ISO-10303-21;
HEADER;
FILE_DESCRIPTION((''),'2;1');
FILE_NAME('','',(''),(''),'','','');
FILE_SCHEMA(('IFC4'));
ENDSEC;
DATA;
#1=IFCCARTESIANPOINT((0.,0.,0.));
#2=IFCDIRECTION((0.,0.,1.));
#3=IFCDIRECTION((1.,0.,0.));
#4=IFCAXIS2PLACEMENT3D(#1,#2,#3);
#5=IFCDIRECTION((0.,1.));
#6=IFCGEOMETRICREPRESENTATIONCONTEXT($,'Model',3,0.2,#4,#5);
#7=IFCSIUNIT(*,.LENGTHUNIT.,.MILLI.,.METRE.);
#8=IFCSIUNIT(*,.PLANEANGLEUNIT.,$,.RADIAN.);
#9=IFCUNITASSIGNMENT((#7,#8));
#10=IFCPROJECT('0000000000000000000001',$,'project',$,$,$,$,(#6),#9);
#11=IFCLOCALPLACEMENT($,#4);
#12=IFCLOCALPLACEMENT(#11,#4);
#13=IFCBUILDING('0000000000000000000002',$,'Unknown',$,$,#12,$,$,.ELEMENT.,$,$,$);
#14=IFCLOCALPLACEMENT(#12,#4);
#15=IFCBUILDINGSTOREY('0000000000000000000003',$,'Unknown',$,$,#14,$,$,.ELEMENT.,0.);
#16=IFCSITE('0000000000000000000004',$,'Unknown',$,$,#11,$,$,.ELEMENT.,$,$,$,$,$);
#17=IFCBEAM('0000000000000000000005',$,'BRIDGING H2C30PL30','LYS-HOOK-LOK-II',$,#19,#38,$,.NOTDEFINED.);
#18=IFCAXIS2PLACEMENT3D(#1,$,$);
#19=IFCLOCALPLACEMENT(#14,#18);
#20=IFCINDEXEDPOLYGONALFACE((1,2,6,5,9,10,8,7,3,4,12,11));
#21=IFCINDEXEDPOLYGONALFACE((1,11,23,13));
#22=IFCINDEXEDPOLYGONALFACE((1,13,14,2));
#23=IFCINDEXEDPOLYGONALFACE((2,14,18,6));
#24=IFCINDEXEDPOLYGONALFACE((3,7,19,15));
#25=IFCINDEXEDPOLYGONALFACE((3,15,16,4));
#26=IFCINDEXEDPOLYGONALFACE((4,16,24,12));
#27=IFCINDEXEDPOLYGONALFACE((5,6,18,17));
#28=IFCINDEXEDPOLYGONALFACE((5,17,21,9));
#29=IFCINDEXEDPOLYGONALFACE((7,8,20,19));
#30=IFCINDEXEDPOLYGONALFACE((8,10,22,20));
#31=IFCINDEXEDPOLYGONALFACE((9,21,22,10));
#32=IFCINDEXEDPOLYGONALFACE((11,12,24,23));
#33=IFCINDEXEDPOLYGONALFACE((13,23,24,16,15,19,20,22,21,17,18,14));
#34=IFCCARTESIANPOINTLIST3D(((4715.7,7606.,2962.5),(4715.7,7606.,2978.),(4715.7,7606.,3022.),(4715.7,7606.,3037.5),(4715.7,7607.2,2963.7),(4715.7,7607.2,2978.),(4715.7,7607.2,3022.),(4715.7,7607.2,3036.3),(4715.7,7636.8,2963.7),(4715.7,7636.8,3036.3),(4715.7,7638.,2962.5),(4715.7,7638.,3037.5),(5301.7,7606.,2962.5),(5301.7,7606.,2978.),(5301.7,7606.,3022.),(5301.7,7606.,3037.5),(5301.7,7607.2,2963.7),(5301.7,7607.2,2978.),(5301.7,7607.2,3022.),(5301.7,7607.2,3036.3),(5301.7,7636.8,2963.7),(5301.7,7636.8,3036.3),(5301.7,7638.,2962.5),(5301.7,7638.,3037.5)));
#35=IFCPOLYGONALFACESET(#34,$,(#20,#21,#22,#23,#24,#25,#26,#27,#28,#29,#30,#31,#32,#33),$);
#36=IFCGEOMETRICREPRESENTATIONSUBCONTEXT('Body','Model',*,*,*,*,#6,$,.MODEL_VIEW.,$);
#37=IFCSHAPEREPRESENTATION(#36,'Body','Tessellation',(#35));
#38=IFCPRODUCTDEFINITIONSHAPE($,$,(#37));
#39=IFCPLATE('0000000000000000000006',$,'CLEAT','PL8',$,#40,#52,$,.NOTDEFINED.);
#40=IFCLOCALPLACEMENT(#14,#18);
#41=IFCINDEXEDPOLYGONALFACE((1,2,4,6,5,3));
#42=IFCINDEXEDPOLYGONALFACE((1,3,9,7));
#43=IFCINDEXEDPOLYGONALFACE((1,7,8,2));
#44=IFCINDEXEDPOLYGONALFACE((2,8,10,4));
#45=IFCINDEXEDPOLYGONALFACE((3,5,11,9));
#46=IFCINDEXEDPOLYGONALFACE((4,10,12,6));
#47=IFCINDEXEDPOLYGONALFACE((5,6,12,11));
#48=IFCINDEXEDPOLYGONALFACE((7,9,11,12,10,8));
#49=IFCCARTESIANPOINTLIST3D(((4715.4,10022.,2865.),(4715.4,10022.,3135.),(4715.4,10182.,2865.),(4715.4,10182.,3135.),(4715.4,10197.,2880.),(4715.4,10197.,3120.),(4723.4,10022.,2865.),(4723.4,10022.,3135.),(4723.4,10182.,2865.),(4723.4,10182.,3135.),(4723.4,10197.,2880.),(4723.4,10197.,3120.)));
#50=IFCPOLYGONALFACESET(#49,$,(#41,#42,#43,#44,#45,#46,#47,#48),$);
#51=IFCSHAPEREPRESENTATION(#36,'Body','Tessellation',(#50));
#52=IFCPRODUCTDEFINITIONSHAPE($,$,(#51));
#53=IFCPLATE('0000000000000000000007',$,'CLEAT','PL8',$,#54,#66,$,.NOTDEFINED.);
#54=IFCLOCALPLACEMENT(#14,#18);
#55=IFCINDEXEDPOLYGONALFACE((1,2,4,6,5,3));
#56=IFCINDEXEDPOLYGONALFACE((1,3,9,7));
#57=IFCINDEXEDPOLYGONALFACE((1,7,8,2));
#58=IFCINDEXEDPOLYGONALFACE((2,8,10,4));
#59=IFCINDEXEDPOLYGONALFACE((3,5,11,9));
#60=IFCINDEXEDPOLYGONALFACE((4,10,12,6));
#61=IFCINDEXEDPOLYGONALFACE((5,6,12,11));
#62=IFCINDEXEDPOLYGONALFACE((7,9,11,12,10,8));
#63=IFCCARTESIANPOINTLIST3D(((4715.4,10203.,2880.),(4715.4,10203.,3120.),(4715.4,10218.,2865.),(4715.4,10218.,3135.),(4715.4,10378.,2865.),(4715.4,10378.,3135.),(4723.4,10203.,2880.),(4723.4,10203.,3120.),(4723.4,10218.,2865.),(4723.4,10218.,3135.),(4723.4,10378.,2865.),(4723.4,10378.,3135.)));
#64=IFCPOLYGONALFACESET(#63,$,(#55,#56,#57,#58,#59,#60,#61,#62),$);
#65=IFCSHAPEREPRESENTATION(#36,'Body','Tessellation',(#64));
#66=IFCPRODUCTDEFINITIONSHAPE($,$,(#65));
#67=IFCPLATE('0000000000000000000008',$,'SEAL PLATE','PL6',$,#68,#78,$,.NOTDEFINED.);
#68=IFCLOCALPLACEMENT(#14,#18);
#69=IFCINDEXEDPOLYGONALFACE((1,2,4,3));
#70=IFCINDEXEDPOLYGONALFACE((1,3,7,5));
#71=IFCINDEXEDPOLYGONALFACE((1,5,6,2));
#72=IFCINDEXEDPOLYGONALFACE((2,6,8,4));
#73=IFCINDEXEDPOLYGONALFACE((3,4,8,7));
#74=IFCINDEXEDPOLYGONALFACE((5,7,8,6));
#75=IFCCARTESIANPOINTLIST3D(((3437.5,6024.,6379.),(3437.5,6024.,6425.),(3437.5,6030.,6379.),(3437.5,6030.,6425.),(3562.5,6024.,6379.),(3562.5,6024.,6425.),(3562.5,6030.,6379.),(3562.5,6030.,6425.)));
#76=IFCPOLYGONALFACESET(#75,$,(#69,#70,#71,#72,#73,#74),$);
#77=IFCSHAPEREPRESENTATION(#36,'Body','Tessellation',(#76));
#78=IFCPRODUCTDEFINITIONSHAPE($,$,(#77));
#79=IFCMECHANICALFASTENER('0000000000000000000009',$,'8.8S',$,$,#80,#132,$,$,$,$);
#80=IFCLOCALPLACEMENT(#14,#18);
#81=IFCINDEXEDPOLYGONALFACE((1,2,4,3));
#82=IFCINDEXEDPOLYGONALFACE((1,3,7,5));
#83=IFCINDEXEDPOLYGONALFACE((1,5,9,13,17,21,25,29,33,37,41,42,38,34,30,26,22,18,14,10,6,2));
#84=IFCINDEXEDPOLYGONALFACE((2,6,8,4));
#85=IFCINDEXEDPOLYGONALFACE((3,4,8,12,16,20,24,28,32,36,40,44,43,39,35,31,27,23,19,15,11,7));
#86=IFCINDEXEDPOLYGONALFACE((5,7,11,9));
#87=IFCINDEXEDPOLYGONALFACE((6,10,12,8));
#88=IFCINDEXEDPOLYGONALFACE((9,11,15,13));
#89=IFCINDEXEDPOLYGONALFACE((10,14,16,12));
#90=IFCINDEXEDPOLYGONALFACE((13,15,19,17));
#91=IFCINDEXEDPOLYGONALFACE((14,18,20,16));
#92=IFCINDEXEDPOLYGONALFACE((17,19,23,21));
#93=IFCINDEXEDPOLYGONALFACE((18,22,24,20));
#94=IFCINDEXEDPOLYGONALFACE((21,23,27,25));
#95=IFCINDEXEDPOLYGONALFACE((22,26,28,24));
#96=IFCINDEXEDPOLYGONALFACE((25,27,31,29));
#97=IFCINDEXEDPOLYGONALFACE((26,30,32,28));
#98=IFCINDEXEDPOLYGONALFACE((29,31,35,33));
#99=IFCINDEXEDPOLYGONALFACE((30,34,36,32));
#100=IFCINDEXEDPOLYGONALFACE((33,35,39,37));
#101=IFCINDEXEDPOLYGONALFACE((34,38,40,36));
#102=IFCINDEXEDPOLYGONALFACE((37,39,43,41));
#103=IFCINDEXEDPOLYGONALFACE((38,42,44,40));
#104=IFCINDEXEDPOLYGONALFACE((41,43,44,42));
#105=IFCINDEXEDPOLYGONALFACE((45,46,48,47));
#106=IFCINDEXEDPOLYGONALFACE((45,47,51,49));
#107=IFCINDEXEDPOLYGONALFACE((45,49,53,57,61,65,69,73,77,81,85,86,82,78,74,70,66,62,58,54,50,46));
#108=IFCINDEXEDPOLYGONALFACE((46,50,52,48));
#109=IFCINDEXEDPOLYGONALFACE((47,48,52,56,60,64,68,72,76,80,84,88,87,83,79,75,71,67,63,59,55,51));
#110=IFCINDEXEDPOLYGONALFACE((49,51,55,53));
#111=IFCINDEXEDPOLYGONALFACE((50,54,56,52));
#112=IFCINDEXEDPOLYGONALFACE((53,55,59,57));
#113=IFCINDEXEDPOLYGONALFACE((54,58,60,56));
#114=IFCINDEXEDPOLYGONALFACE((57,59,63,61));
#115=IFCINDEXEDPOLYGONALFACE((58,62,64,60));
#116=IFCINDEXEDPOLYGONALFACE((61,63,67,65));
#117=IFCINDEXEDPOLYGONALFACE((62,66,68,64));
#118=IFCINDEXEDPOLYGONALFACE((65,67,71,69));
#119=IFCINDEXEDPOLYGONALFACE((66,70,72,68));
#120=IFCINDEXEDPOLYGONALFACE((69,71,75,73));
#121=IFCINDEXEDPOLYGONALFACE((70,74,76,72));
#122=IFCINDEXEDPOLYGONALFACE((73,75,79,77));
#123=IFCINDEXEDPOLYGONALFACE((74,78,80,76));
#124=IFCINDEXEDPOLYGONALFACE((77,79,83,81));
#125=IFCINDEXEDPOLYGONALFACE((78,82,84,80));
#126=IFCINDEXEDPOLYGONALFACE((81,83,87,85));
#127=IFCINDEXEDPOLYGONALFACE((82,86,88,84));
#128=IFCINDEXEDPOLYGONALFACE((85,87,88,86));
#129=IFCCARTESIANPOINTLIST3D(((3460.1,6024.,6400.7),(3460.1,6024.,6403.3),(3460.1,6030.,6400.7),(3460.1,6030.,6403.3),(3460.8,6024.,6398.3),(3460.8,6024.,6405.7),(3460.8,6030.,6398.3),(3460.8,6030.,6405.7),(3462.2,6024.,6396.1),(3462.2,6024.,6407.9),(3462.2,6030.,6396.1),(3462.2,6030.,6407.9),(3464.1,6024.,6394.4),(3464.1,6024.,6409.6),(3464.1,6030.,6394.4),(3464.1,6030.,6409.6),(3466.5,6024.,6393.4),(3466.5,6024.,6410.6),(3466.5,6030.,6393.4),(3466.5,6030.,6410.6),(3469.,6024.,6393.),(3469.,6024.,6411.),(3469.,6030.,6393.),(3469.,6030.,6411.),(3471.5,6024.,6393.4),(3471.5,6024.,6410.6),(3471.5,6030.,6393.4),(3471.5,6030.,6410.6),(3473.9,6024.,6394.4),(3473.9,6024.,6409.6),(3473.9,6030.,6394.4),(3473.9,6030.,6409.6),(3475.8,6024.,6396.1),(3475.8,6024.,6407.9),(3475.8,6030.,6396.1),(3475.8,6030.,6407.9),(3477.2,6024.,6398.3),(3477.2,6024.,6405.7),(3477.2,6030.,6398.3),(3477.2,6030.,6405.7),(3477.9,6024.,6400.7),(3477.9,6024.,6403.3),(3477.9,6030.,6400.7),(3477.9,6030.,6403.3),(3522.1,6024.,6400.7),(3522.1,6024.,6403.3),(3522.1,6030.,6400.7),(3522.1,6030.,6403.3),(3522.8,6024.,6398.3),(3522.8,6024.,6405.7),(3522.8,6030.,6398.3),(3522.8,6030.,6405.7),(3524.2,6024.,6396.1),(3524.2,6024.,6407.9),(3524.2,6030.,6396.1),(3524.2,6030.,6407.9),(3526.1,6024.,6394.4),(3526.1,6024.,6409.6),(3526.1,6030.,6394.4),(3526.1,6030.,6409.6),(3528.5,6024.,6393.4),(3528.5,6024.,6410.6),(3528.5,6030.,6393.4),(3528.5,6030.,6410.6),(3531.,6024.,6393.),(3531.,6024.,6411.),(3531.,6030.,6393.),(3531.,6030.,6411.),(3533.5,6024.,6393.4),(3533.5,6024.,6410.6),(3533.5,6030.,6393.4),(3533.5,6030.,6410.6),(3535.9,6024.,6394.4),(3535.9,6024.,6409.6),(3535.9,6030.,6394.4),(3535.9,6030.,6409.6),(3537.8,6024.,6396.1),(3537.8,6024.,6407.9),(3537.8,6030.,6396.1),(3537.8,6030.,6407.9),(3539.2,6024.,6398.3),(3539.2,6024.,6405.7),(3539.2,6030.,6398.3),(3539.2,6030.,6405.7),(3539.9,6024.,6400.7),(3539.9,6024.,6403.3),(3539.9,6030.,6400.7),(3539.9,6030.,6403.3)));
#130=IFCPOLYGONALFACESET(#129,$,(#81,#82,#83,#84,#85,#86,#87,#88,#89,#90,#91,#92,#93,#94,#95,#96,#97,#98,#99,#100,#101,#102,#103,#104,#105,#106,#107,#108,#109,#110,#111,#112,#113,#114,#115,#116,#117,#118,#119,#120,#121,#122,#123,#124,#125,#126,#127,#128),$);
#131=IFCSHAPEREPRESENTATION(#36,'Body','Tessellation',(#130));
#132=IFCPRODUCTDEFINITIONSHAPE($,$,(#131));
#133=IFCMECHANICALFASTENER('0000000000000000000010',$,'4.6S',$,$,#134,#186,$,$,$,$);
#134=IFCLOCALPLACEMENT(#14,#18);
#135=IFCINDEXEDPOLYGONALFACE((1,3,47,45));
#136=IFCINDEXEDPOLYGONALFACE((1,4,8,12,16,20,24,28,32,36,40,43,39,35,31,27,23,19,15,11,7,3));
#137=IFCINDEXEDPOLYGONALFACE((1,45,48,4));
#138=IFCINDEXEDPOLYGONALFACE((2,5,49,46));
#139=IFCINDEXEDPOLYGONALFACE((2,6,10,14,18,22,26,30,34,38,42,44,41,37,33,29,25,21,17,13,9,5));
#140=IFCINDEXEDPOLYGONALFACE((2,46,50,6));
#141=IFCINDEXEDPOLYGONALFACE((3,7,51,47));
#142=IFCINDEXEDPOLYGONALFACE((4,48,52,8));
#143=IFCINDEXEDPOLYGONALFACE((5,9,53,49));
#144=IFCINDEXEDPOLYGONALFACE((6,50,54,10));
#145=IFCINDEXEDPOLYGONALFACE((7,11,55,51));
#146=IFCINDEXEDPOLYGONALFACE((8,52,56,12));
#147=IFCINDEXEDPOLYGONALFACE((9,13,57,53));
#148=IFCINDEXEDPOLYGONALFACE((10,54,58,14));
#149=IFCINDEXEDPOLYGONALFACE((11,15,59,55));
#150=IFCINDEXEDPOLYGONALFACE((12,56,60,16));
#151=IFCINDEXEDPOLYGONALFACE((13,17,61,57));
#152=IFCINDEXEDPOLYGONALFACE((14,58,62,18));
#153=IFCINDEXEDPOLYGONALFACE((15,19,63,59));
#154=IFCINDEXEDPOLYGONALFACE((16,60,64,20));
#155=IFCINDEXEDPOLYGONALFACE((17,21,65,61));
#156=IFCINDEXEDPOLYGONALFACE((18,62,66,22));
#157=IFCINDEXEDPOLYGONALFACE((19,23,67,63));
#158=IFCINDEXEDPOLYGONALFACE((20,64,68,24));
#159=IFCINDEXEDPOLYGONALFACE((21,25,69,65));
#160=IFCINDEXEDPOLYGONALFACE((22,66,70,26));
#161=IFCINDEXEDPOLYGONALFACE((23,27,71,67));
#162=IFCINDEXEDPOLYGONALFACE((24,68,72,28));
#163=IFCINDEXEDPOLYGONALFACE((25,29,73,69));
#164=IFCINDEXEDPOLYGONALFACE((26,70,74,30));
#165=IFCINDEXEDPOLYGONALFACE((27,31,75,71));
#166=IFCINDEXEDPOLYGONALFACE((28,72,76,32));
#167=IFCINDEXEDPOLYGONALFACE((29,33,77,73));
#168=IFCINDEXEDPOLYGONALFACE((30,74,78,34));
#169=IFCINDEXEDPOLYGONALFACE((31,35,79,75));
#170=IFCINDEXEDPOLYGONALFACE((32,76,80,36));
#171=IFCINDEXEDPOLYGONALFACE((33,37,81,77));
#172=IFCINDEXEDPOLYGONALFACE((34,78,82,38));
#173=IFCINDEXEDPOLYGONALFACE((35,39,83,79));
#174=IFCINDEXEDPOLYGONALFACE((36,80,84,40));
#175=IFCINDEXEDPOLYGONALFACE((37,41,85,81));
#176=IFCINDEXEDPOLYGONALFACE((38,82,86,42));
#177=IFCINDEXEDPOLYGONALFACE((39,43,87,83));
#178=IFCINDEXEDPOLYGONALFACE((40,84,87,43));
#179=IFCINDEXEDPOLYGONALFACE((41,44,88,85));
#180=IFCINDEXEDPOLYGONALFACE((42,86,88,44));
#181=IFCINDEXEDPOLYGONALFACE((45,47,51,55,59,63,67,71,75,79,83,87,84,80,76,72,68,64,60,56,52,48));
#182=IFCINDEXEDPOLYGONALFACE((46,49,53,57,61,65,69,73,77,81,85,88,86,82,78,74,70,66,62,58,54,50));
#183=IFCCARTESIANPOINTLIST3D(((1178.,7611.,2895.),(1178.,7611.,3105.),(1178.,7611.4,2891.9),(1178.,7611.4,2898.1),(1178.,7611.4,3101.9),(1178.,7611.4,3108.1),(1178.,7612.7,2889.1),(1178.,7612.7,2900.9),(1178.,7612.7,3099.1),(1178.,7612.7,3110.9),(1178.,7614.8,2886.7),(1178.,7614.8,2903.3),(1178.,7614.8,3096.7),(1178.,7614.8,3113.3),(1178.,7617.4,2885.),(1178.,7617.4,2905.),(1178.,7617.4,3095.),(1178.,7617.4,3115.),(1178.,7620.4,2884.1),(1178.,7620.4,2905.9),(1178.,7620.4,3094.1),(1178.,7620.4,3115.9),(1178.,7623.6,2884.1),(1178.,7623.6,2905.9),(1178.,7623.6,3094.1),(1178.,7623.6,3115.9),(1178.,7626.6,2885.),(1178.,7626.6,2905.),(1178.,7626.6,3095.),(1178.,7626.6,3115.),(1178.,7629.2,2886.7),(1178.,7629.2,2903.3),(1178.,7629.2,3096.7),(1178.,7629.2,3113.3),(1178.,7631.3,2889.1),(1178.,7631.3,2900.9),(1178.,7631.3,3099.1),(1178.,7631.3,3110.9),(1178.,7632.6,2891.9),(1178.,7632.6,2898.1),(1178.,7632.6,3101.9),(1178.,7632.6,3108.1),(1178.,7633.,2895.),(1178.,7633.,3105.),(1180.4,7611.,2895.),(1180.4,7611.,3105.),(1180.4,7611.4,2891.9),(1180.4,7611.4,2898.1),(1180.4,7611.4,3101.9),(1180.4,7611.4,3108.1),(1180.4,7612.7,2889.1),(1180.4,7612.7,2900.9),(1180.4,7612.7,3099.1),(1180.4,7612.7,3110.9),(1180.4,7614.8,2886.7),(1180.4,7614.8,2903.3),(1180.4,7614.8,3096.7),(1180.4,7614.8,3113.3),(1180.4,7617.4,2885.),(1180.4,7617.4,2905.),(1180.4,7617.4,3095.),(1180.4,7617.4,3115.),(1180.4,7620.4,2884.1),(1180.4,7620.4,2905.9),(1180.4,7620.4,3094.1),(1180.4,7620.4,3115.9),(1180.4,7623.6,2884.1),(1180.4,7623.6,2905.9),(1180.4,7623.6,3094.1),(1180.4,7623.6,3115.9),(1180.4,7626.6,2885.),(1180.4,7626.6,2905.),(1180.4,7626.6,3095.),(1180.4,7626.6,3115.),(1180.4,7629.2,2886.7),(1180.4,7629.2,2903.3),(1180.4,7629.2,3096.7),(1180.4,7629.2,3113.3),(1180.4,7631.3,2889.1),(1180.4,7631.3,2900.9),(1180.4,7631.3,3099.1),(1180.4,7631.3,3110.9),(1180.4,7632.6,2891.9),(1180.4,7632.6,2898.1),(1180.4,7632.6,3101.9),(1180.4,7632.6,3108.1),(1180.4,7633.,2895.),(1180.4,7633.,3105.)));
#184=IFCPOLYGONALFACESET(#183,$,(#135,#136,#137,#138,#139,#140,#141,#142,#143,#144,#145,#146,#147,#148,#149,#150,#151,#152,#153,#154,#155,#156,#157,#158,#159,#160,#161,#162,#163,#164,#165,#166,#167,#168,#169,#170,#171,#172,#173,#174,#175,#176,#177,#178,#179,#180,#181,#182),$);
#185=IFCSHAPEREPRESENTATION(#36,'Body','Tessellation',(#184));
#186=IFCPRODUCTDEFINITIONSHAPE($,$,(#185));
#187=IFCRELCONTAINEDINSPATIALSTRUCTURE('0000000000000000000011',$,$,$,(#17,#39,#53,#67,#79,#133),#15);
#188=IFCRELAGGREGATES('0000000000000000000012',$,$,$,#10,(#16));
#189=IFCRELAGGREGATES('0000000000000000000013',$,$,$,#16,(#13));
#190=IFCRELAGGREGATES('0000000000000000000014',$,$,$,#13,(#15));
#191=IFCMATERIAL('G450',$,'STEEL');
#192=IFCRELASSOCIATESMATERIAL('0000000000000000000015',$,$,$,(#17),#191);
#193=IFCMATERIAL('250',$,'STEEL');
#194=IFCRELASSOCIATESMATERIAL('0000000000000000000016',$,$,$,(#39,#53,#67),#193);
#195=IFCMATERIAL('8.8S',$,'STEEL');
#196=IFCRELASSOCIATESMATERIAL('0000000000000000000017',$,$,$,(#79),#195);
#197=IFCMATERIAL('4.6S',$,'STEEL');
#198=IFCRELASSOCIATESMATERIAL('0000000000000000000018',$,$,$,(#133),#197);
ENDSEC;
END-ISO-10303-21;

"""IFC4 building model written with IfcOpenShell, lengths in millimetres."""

from ifc_helpers import new_model, si_unit, direction, frame, origin_with_axes, place, context, subcontext, project, spatial, line, arc, indexed_curve, outline, extrude, source, transform, mapped, material, element, save


model = new_model("IFC4")

# Units and contexts
model_context = context("Model", 3, precision=0.2, world=origin_with_axes(), true_north=direction((0.0, 1.0)))
body_context = subcontext(model_context, "Body", "Model", "MODEL_VIEW")
ifc_project = project(units=[si_unit("LENGTHUNIT", "METRE", prefix="MILLI"), si_unit("PLANEANGLEUNIT", "RADIAN")], contexts=[model_context])

# Site, building, storey
site_placement = place(None, origin_with_axes())
site = spatial("IfcSite", under=ifc_project, at=site_placement, Name="Unknown", CompositionType="ELEMENT")
building_placement = place(site_placement, origin_with_axes())
building = spatial("IfcBuilding", under=site, at=building_placement, Name="Unknown", CompositionType="ELEMENT")
storey_placement = place(building_placement, origin_with_axes())
storey = spatial("IfcBuildingStorey", under=building, at=storey_placement, Name="Unknown", CompositionType="ELEMENT", Elevation=0.0)

# Beam
ifc_material_1 = material(Name="G450", Category="STEEL")
for number, where, z_axis, x_axis, name in (
    (1, (4715.7, 7622.0, 3000.0), (0.0, -1.0, 0.0), (1.0, 0.0, 0.0), "BRIDGING H2C30PL30"),
):
    element("IfcBeam", number, at=place(storey_placement, frame(where, z_axis=z_axis, x_axis=x_axis)), inside=storey, material=ifc_material_1, Name=name, Description="LYS-HOOK-LOK-II", PredefinedType="NOTDEFINED", context=body_context, shape_type="SolidModel", body=[
        extrude(outline(indexed_curve([(16.0, -37.5), (16.0, -22.0), (14.8, -22.0), (14.8, -36.3), (-14.8, -36.3), (-14.8, 36.3), (14.8, 36.3), (14.8, 22.0), (16.0, 22.0), (16.0, 37.5), (-16.0, 37.5), (-16.0, -37.5)], segments=[line(1, 2, 3, 4, 5, 6, 7, 8, 9, 10, 11, 12, 1)])), frame((0.0, 0.0, 0.0), z_axis=(-1.0, 0.0, 0.0), x_axis=(0.0, 0.0, 1.0)), (0.0, 0.0, -1.0), 586.0),
    ])

# Plates
ifc_material_2 = material(Name="250", Category="STEEL")
for number, where, z_axis, x_axis, name in (
    (2, (4719.4, 10197.0, 2865.0), (-1.0, 0.0, 0.0), (0.0, -1.0, 0.0), "CLEAT"),
    (3, (4719.4, 10203.0, 2865.0), (1.0, 0.0, 0.0), (0.0, 1.0, 0.0), "CLEAT"),
):
    element("IfcPlate", number, at=place(storey_placement, frame(where, z_axis=z_axis, x_axis=x_axis)), inside=storey, material=ifc_material_2, Name=name, Description="PL8", PredefinedType="NOTDEFINED", context=body_context, shape_type="SolidModel", body=[
        extrude(outline(indexed_curve([(0.0, 15.0), (15.0, 0.0), (174.9, 0.0), (174.9, 270.0), (15.0, 270.0), (0.0, 255.0)], segments=[line(1, 2, 3, 4, 5, 6, 1)])), frame((0.0, 0.0, 4.0), z_axis=(0.0, 0.0, 1.0), x_axis=(1.0, 0.0, 0.0)), (0.0, 0.0, -1.0), 8.0),
    ])
plate_placement = place(storey_placement, frame((3437.5, 6027.0, 6379.0), z_axis=(0.0, -1.0, 0.0), x_axis=(1.0, 0.0, 0.0)))
element("IfcPlate", 4, at=plate_placement, inside=storey, material=ifc_material_2, Name="SEAL PLATE", Description="PL6", PredefinedType="NOTDEFINED", context=body_context, shape_type="SolidModel", body=[
    extrude(outline(indexed_curve([(0.0, 0.0), (125.0, 0.0), (125.0, 46.0), (0.0, 46.0)], segments=[line(1, 2, 3, 4, 1)])), frame((0.0, 0.0, 3.0), z_axis=(0.0, 0.0, 1.0), x_axis=(1.0, 0.0, 0.0)), (0.0, 0.0, -1.0), 6.0),
])

# Mechanical fasteners
ifc_material_3 = material(Name="8.8S", Category="STEEL")
shared_shape_1 = source(origin_with_axes(), body_context, "Body", "SweptSolid", [
    extrude(outline(indexed_curve([(9.0, 0.0), (0.0, 9.0), (-9.0, 0.0), (0.0, -9.0)], segments=[arc(1, 2, 3), arc(3, 4, 1)])), frame((0.0, 0.0, 3.0), z_axis=(0.0, 0.0, -1.0), x_axis=(0.0, 1.0, 0.0)), (0.0, 0.0, 1.0), 6.0),
])
mechanical_fastener_placement = place(storey_placement, frame((3469.0, 6027.0, 6402.0), z_axis=(0.0, -1.0, 0.0), x_axis=(1.0, 0.0, 0.0)))
element("IfcMechanicalFastener", 5, at=mechanical_fastener_placement, inside=storey, material=ifc_material_3, Name="8.8S", context=body_context, shape_type="MappedRepresentation", body=[
    mapped(shared_shape_1, transform((0.0, 0.0, 0.0))),
    mapped(shared_shape_1, transform((62.0, 0.0, 0.0))),
])
ifc_material_4 = material(Name="4.6S", Category="STEEL")
shared_shape_2 = source(origin_with_axes(), body_context, "Body", "SweptSolid", [
    extrude(outline(indexed_curve([(11.0, 0.0), (0.0, 11.0), (-11.0, 0.0), (0.0, -11.0)], segments=[arc(1, 2, 3), arc(3, 4, 1)])), frame((0.0, 0.0, 1.2), z_axis=(0.0, 0.0, -1.0), x_axis=(0.0, 1.0, 0.0)), (0.0, 0.0, 1.0), 2.4),
])
for number, where, z_axis, x_axis, name in (
    (6, (1179.2, 7622.0, 2895.0), (-1.0, 0.0, 0.0), (0.0, 0.0, 1.0), "4.6S"),
):
    element("IfcMechanicalFastener", number, at=place(storey_placement, frame(where, z_axis=z_axis, x_axis=x_axis)), inside=storey, material=ifc_material_4, Name=name, context=body_context, shape_type="MappedRepresentation", body=[
        mapped(shared_shape_2, transform((0.0, 0.0, 0.0))),
        mapped(shared_shape_2, transform((210.0, 0.0, 0.0))),
    ])

save(model, "model.ifc")
